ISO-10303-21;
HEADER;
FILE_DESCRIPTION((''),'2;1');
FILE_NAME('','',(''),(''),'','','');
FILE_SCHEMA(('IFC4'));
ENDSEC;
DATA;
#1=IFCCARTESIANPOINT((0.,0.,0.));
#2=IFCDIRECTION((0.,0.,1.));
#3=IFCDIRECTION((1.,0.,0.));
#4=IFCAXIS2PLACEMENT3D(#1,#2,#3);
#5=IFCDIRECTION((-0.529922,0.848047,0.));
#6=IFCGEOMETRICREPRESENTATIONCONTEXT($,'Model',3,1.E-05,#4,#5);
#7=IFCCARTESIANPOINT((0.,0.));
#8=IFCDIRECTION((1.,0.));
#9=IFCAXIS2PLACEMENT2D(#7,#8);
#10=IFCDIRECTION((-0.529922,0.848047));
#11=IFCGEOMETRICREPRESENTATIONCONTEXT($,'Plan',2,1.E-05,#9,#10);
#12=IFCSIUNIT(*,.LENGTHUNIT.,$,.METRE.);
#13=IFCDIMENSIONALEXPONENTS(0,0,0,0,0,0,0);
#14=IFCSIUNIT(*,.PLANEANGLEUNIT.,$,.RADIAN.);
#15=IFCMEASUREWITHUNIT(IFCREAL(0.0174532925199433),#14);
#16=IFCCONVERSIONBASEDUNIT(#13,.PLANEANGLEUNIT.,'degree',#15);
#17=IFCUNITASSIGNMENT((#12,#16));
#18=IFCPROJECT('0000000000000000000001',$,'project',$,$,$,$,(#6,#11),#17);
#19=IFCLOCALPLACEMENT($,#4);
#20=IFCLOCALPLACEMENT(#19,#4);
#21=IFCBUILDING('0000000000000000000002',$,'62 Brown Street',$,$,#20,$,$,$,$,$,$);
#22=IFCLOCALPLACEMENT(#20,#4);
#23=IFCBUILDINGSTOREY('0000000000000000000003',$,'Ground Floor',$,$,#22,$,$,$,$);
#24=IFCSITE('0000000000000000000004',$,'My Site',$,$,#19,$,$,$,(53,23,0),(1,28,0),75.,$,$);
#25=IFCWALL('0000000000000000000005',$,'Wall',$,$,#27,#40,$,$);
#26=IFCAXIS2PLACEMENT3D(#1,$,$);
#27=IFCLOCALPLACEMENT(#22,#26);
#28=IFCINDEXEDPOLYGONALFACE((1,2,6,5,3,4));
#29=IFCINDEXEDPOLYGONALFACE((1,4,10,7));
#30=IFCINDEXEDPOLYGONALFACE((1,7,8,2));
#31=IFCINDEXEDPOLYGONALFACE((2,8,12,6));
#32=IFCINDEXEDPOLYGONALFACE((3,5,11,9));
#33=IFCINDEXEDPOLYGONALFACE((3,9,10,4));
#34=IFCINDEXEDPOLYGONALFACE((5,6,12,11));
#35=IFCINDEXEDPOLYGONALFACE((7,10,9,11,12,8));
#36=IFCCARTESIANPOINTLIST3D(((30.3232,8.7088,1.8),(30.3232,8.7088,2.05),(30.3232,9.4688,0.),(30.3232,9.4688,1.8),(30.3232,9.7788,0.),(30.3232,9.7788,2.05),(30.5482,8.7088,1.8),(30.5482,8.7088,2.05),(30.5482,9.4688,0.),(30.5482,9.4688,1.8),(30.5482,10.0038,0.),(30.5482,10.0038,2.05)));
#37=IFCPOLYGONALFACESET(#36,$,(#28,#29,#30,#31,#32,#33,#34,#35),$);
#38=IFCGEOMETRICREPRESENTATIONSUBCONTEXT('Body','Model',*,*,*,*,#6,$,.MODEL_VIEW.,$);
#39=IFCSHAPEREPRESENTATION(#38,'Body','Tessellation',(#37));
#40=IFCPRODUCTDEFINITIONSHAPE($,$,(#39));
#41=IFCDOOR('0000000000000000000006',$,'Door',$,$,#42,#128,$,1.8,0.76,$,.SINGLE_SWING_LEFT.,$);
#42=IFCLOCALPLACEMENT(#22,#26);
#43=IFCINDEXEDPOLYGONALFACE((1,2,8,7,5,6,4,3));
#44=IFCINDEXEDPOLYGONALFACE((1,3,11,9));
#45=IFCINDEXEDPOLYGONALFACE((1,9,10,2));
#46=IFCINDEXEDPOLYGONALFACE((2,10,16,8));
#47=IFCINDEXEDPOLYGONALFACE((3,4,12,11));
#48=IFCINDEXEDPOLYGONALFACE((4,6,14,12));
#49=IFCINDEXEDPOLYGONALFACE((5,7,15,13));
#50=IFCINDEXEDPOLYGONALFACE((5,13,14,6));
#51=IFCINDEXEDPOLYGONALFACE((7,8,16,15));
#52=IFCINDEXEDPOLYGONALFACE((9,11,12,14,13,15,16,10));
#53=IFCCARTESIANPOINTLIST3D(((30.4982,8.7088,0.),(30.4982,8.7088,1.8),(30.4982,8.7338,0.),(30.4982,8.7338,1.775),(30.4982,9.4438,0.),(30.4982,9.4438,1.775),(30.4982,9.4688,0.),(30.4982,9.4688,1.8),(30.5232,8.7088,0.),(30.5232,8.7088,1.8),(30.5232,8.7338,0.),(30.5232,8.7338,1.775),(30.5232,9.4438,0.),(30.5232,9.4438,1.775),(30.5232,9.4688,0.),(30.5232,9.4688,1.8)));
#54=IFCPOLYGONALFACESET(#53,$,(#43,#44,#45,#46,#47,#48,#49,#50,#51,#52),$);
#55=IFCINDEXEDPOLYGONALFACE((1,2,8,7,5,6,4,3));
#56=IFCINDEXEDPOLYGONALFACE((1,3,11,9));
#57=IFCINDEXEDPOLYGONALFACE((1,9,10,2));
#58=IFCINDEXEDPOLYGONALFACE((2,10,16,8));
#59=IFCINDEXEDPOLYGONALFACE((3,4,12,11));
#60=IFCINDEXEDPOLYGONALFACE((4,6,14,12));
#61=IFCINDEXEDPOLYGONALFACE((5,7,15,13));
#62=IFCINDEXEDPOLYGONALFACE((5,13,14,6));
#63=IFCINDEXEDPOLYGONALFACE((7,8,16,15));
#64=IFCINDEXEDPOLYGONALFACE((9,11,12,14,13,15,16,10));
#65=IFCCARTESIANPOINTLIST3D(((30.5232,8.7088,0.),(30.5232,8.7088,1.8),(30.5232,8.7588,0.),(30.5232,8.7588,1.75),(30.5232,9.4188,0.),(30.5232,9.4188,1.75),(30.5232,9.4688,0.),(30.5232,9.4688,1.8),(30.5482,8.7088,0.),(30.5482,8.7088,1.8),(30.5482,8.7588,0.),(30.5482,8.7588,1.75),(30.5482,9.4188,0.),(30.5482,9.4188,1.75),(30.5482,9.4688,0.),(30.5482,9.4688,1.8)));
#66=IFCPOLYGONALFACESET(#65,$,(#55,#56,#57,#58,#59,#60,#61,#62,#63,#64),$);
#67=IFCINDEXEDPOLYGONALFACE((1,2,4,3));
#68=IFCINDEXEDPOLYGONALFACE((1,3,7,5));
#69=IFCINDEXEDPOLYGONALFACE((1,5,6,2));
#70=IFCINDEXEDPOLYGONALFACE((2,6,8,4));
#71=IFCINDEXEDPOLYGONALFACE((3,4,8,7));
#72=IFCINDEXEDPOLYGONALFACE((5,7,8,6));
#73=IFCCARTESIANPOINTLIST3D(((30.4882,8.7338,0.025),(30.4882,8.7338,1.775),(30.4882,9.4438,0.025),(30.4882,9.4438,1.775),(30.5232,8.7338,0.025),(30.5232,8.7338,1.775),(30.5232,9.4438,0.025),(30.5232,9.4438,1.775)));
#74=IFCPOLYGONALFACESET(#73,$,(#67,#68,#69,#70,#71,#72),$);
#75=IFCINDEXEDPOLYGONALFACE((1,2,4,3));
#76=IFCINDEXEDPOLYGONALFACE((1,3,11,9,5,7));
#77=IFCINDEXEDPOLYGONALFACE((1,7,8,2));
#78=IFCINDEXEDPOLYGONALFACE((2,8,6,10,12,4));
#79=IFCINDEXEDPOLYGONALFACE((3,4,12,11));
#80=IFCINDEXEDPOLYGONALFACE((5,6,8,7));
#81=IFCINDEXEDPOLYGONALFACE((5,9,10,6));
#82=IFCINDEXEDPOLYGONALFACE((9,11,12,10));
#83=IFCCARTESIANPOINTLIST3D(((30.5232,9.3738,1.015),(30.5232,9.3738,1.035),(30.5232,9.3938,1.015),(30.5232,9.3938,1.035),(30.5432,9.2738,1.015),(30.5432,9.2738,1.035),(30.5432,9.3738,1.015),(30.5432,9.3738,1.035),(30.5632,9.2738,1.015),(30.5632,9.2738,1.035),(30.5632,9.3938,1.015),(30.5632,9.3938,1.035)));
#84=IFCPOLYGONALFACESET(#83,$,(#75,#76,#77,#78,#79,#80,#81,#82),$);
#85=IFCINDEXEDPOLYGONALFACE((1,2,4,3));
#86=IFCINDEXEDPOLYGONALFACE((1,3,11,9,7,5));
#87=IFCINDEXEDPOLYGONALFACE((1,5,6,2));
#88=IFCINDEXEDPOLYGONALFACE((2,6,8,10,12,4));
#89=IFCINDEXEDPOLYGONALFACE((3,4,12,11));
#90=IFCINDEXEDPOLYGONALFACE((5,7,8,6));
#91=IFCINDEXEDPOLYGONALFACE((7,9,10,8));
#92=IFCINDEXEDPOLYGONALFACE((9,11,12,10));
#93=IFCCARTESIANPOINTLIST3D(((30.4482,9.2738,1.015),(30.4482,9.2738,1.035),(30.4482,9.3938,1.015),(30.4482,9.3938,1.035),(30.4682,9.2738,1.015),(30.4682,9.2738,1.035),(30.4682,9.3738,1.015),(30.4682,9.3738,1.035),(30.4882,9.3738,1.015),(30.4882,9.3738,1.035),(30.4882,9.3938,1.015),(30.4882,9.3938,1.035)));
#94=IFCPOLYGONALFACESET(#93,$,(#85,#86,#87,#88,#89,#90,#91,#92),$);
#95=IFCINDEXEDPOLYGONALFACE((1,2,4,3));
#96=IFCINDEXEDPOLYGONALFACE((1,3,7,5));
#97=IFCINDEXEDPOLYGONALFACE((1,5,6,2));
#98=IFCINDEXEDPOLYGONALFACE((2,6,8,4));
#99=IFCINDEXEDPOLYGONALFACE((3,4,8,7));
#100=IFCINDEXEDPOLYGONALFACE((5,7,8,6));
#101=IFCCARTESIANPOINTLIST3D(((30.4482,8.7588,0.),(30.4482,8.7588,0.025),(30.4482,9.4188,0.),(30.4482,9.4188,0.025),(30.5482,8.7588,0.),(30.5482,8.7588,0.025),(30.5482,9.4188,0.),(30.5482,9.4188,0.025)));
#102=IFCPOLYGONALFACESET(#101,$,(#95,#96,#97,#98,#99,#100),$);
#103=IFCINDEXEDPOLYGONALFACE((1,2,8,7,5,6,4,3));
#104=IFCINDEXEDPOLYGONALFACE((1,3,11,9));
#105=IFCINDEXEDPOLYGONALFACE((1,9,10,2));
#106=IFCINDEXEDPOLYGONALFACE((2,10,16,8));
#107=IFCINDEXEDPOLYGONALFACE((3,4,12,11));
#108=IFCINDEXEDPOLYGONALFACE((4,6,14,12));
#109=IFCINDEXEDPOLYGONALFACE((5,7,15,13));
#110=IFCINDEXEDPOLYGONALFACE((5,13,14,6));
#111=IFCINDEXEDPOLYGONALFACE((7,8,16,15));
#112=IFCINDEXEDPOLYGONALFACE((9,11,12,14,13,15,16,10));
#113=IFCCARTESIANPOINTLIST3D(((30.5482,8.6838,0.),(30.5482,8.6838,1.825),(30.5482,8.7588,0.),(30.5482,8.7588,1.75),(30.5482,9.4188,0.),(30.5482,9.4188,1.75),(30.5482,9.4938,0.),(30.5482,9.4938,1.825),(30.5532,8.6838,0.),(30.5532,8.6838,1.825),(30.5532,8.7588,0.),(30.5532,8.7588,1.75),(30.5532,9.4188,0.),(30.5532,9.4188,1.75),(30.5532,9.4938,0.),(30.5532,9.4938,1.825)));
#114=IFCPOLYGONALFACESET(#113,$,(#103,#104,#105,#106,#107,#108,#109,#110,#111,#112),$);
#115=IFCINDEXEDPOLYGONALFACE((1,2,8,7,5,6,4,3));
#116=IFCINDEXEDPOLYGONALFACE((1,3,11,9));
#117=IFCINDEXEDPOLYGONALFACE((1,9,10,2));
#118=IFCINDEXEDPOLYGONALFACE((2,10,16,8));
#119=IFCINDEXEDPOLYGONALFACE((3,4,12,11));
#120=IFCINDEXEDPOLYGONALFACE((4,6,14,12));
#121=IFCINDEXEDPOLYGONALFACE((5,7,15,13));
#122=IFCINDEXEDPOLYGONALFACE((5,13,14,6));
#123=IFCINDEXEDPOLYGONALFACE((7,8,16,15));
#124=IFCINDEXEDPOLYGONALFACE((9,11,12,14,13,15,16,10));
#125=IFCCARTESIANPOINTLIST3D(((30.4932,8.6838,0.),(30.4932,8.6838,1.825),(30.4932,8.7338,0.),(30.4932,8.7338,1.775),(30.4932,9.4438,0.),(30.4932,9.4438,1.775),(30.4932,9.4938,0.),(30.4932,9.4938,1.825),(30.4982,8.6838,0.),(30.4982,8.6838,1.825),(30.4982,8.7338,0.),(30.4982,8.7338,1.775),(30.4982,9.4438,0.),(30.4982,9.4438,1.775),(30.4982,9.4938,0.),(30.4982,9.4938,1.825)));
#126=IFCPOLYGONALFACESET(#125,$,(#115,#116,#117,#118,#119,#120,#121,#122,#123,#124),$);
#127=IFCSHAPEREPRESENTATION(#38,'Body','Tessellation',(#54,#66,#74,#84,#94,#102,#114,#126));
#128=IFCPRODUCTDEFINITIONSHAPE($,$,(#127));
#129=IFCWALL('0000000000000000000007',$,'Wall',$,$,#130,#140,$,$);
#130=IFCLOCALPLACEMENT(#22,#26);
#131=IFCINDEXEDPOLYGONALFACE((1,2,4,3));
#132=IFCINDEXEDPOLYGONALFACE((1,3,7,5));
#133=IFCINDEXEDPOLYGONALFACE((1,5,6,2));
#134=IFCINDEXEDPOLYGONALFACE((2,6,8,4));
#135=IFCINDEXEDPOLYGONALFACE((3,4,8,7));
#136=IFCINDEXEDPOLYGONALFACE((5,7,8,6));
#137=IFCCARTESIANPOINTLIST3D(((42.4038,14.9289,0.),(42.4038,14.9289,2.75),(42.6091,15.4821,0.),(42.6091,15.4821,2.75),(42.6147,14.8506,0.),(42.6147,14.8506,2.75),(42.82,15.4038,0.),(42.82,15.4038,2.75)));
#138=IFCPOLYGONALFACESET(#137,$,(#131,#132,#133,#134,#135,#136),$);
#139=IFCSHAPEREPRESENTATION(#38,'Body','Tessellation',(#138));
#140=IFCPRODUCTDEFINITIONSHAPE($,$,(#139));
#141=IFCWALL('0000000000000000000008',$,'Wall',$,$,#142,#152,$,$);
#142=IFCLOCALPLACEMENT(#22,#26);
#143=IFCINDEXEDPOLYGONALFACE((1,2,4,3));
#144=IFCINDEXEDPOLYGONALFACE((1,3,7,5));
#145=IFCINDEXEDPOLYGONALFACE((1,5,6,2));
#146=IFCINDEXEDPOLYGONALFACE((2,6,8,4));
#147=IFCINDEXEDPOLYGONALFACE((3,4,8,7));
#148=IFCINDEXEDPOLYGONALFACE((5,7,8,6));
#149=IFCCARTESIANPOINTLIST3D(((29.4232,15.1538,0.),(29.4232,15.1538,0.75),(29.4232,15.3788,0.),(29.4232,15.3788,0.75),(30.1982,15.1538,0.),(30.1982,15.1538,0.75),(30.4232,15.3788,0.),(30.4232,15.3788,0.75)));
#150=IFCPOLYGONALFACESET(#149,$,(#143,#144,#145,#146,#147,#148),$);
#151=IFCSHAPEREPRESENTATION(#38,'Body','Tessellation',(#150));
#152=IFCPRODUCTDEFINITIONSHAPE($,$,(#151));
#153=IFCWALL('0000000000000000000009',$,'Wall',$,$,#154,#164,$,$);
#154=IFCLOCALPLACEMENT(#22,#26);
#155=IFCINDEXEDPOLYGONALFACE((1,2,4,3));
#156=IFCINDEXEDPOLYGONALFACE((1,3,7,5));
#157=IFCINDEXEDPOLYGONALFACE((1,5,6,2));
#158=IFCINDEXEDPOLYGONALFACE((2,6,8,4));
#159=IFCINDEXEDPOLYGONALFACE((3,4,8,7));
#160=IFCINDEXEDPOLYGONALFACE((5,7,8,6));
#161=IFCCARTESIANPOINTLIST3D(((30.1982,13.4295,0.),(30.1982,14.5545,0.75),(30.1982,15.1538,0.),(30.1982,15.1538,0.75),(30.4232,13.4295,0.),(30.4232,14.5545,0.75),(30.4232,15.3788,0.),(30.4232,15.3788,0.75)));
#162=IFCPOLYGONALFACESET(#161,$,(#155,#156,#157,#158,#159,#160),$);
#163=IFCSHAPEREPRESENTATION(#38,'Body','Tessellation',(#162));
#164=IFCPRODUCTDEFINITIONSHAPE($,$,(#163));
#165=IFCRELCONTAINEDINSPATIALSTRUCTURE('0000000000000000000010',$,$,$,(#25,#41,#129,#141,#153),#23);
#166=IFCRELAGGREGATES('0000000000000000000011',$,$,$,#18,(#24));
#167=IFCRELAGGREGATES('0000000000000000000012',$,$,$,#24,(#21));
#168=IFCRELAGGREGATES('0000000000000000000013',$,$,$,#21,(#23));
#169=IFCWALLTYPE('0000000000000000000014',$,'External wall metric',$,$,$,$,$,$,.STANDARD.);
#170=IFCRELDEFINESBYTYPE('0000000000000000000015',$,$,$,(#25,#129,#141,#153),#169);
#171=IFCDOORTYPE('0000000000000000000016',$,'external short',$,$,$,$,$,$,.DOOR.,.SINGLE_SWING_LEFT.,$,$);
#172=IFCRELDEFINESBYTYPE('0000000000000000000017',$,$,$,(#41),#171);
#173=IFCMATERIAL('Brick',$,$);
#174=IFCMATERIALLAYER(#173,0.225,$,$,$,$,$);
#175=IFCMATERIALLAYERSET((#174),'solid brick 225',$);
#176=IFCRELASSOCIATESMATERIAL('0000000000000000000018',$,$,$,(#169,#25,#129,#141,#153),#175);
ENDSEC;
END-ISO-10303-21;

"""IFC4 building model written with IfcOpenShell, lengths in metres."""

from ifc_helpers import new_model, entity, si_unit, converted_unit, direction, frame, origin_with_axes, origin_2d_with_axis, place, context, subcontext, project, spatial, line, indexed_curve, outline, extrude, clip, halfspace, shape, source, transform, mapped, material, layer, layer_set, layer_usage, type_object, type_shapes, element, fill, save


model = new_model("IFC4")

# Units and contexts
model_context = context("Model", 3, precision=1e-05, world=origin_with_axes(), true_north=direction((-0.529922, 0.848047, 0.0)))
plan_context = context("Plan", 2, precision=1e-05, world=origin_2d_with_axis(), true_north=direction((-0.529922, 0.848047)))
body_context_1 = subcontext(model_context, "Body", "Model", "MODEL_VIEW")
body_context_2 = subcontext(plan_context, "Body", "Plan", "PLAN_VIEW")
ifc_project = project(units=[si_unit("LENGTHUNIT", "METRE"), converted_unit("PLANEANGLEUNIT", "degree", entity("IfcReal", 0.0174532925199433), si_unit("PLANEANGLEUNIT", "RADIAN"), dimensions=[0, 0, 0, 0, 0, 0, 0])], contexts=[model_context, plan_context])

# Site, building, storey
site_placement = place(None, origin_with_axes())
site = spatial("IfcSite", under=ifc_project, at=site_placement, Name="My Site", RefLatitude=(53, 23, 0), RefLongitude=(1, 28, 0), RefElevation=75.0)
building_placement = place(site_placement, origin_with_axes())
building = spatial("IfcBuilding", under=site, at=building_placement, Name="62 Brown Street")
storey_placement = place(building_placement, origin_with_axes())
storey = spatial("IfcBuildingStorey", under=building, at=storey_placement, Name="Ground Floor")

# Shared definitions
ifc_material_1 = material(Name="Brick")
ifc_layer_1 = layer(ifc_material_1, 0.225)
ifc_layer_set_1 = layer_set([ifc_layer_1], Name="solid brick 225")
wall_type_1 = type_object("IfcWallType", Name="External wall metric", PredefinedType="STANDARD", material=ifc_layer_set_1)

# Wall, opening, door
ifc_layer_usage_1 = layer_usage(ifc_layer_set_1, "AXIS2", "POSITIVE", 0.0)
wall_1_placement = place(storey_placement, frame((30.5482, 8.7088, 0.0), z_axis=(0.0, 0.0, 1.0), x_axis=(0.0, 1.0, 0.0)))
wall_1 = element("IfcWall", 1, at=wall_1_placement, inside=storey, type_object=wall_type_1, material=ifc_layer_usage_1, Name="Wall", context=body_context_1, shape_type="Clipping", body=[
    clip(extrude(outline(indexed_curve([(0.0, 0.0), (0.0, 0.225), (1.295, 0.225), (1.295, 0.0), (0.0, 0.0)], self_intersect=False)), origin_with_axes(), (0.0, 0.0, 1.0), 2.05), halfspace(frame((1.295, 0.0, 0.0), z_axis=(0.450001, 0.450001, 0.0), x_axis=(-0.225, 0.225, 0.0)), False)),
])
shared_shape_1 = source(origin_with_axes(), body_context_1, "Body", "SweptSolid", [
    extrude(outline(indexed_curve([(0.0, 0.0), (0.76, 0.0), (0.76, 1.8), (0.0, 1.8)], segments=[line(1, 2, 3, 4, 1)])), frame((0.0, -0.1, 0.0), z_axis=(0.0, -1.0, 0.0), x_axis=(1.0, 0.0, 0.0)), (0.0, 0.0, -1.0), 0.425),
])
opening_1_placement = place(wall_1_placement, frame((0.0, 0.0, 0.0), z_axis=(0.0, 0.0, 1.0), x_axis=(1.0, 0.0, 0.0)))
opening_1 = element("IfcOpeningElement", 2, at=opening_1_placement, cuts=wall_1, PredefinedType="OPENING", context=body_context_1, shape_type="MappedRepresentation", body=[
    mapped(shared_shape_1, transform((0.0, 0.0, 0.0), x_axis=(1.0, 0.0, 0.0), y_axis=(0.0, 1.0, 0.0), z_axis=(0.0, 0.0, 1.0), scale=1.0)),
])
door_type_1 = type_object("IfcDoorType", Name="external short", OperationType="SINGLE_SWING_LEFT", PredefinedType="DOOR")
shared_shape_2 = source(origin_with_axes(), body_context_1, "Body", "SweptSolid", [
    extrude(outline(indexed_curve([(0.0, 0.0), (0.0, 1.8), (0.76, 1.8), (0.76, 0.0), (0.735, 0.0), (0.735, 1.775), (0.025, 1.775), (0.025, 0.0)], segments=[line(1, 2, 3, 4, 5, 6, 7, 8, 1)])), frame((0.0, 0.025, 0.0), z_axis=(0.0, -1.0, 0.0), x_axis=(1.0, 0.0, 0.0)), (0.0, 0.0, -1.0), 0.025),
    extrude(outline(indexed_curve([(0.0, 0.0), (0.0, 1.8), (0.76, 1.8), (0.76, 0.0), (0.71, 0.0), (0.71, 1.75), (0.05, 1.75), (0.05, 0.0)], segments=[line(1, 2, 3, 4, 5, 6, 7, 8, 1)])), frame((0.0, 0.0, 0.0), z_axis=(0.0, -1.0, 0.0), x_axis=(1.0, 0.0, 0.0)), (0.0, 0.0, -1.0), 0.025),
    extrude(outline(indexed_curve([(0.0, 0.0), (0.71, 0.0), (0.71, 0.035), (0.0, 0.035)], segments=[line(1, 2, 3, 4, 1)])), frame((0.025, 0.025, 0.025), z_axis=(0.0, 0.0, 1.0), x_axis=(1.0, 0.0, 0.0)), (0.0, 0.0, 1.0), 1.75),
    extrude(outline(indexed_curve([(0.0, 0.0), (0.0, -0.04), (-0.12, -0.04), (-0.12, -0.02), (-0.02, -0.02), (-0.02, 0.0)], segments=[line(1, 2, 3, 4, 5, 6, 1)])), frame((0.685, 0.025, 1.015), z_axis=(0.0, 0.0, 1.0), x_axis=(1.0, 0.0, 0.0)), (0.0, 0.0, 1.0), 0.02),
    extrude(outline(indexed_curve([(0.0, 0.0), (0.0, 0.04), (-0.12, 0.04), (-0.12, 0.02), (-0.02, 0.02), (-0.02, 0.0)], segments=[line(1, 2, 3, 4, 5, 6, 1)])), frame((0.685, 0.06, 1.015), z_axis=(0.0, 0.0, 1.0), x_axis=(1.0, 0.0, 0.0)), (0.0, 0.0, 1.0), 0.02),
    extrude(outline(indexed_curve([(0.0, 0.0), (0.66, 0.0), (0.66, 0.1), (0.0, 0.1)], segments=[line(1, 2, 3, 4, 1)])), frame((0.05, 0.0, 0.0), z_axis=(0.0, 0.0, 1.0), x_axis=(1.0, 0.0, 0.0)), (0.0, 0.0, 1.0), 0.025),
    extrude(outline(indexed_curve([(0.0, 0.0), (0.0, 1.825), (0.81, 1.825), (0.81, 0.0), (0.735, 0.0), (0.735, 1.75), (0.075, 1.75), (0.075, 0.0)], segments=[line(1, 2, 3, 4, 5, 6, 7, 8, 1)])), frame((-0.025, -0.005, 0.0), z_axis=(0.0, -1.0, 0.0), x_axis=(1.0, 0.0, 0.0)), (0.0, 0.0, -1.0), 0.005),
    extrude(outline(indexed_curve([(0.0, 0.0), (0.0, 1.825), (0.81, 1.825), (0.81, 0.0), (0.76, 0.0), (0.76, 1.775), (0.05, 1.775), (0.05, 0.0)], segments=[line(1, 2, 3, 4, 5, 6, 7, 8, 1)])), frame((-0.025, 0.05, 0.0), z_axis=(0.0, -1.0, 0.0), x_axis=(1.0, 0.0, 0.0)), (0.0, 0.0, -1.0), 0.005),
])
shared_shape_3 = source(origin_with_axes(), body_context_2, "Body", "Curve2D", [
    entity("IfcIndexedPolyCurve", entity("IfcCartesianPointList2D", [[0.0, 0.0], [0.0, 0.05], [0.025, 0.05], [0.025, 0.025], [0.05, 0.025], [0.05, 0.0]]), [entity("IfcLineIndex", [1, 2, 3, 4, 5, 6, 1])]),
    entity("IfcIndexedPolyCurve", entity("IfcCartesianPointList2D", [[0.76, 0.0], [0.76, 0.05], [0.735, 0.05], [0.735, 0.025], [0.71, 0.025], [0.71, 0.0]]), [entity("IfcLineIndex", [1, 2, 3, 4, 5, 6, 1])]),
    entity("IfcTrimmedCurve", entity("IfcEllipse", entity("IfcAxis2Placement2D", entity("IfcCartesianPoint", [0.06, 0.05]), entity("IfcDirection", [1.0, 0.0])), 0.675, 0.71), [entity("IfcCartesianPoint", [0.735, 0.05])], [entity("IfcCartesianPoint", [0.06, 0.76])], True, "CARTESIAN"),
    entity("IfcIndexedPolyCurve", entity("IfcCartesianPointList2D", [[0.025, 0.05], [0.06, 0.05], [0.06, 0.76], [0.025, 0.76]]), [entity("IfcLineIndex", [1, 2, 3, 4, 1])]),
])
type_shapes(door_type_1, [shared_shape_2, shared_shape_3])
door_1_placement = place(opening_1_placement, frame((0.0, 0.0, 0.0), z_axis=(0.0, 0.0, 1.0), x_axis=(1.0, 0.0, 0.0)))
door_1 = element("IfcDoor", 3, at=door_1_placement, inside=storey, type_object=door_type_1, Name="Door", OperationType="SINGLE_SWING_LEFT", OverallHeight=1.8, OverallWidth=0.76, shapes=[
    shape(body_context_1, "Body", "MappedRepresentation", [mapped(shared_shape_2, transform((0.0, 0.0, 0.0), x_axis=(1.0, 0.0, 0.0), y_axis=(0.0, 1.0, 0.0), z_axis=(0.0, 0.0, 1.0), scale=1.0))]),
    shape(body_context_2, "Body", "MappedRepresentation", [mapped(shared_shape_3, transform((0.0, 0.0, 0.0), x_axis=(1.0, 0.0, 0.0), y_axis=(0.0, 1.0, 0.0), z_axis=(0.0, 0.0, 1.0), scale=1.0))]),
])
fill(opening_1, door_1)

# Walls
ifc_layer_usage_2 = layer_usage(ifc_layer_set_1, "AXIS2", "POSITIVE", 0.0)
wall_2_placement = place(storey_placement, frame((42.6147, 14.8506, 0.0), z_axis=(0.0, 0.0, 1.0), x_axis=(0.347944, 0.937515, 0.0)))
element("IfcWall", 4, at=wall_2_placement, inside=storey, type_object=wall_type_1, material=ifc_layer_usage_2, Name="Wall", context=body_context_1, shape_type="SweptSolid", body=[
    extrude(outline(indexed_curve([(0.0, 0.0), (0.0, 0.225), (0.5901, 0.225), (0.5901, 0.0), (0.0, 0.0)], self_intersect=False)), origin_with_axes(), (0.0, 0.0, 1.0), 2.75),
])
ifc_layer_usage_3 = layer_usage(ifc_layer_set_1, "AXIS2", "POSITIVE", 0.0)
wall_3_placement = place(storey_placement, frame((30.4232, 15.3788, 0.0), z_axis=(0.0, 0.0, 1.0), x_axis=(-1.0, 0.0, 0.0)))
element("IfcWall", 5, at=wall_3_placement, inside=storey, type_object=wall_type_1, material=ifc_layer_usage_3, Name="Wall", context=body_context_1, shape_type="Clipping", body=[
    clip(extrude(outline(indexed_curve([(0.0, 0.0), (0.0, 0.225), (1.0, 0.225), (1.0, 0.0), (0.0, 0.0)], self_intersect=False)), origin_with_axes(), (0.0, 0.0, 1.0), 0.75), halfspace(frame((0.0, 0.0, 0.0), z_axis=(-0.707107, 0.707107, 0.0), x_axis=(0.707107, 0.707107, 0.0)), False)),
])
ifc_layer_usage_4 = layer_usage(ifc_layer_set_1, "AXIS2", "POSITIVE", 0.0)
wall_4_placement = place(storey_placement, frame((30.4232, 13.4295, 0.0), z_axis=(0.0, 0.0, 1.0), x_axis=(0.0, 1.0, 0.0)))
element("IfcWall", 6, at=wall_4_placement, inside=storey, type_object=wall_type_1, material=ifc_layer_usage_4, Name="Wall", context=body_context_1, shape_type="Clipping", body=[
    clip(clip(extrude(outline(indexed_curve([(0.0, 0.0), (0.0, 0.225), (1.9493, 0.225), (1.9493, 0.0), (0.0, 0.0)], self_intersect=False)), origin_with_axes(), (0.0, 0.0, 1.0), 0.75), halfspace(frame((0.416, 0.5, 0.2774), z_axis=(-0.5547, 0.0, 0.83205), x_axis=(0.0, -1.0, 0.0)), False)), halfspace(frame((1.9493, 0.0, 0.0), z_axis=(0.707107, 0.707107, 0.0), x_axis=(0.707107, -0.707107, 0.0)), False)),
])

save(model, "model.ifc")
